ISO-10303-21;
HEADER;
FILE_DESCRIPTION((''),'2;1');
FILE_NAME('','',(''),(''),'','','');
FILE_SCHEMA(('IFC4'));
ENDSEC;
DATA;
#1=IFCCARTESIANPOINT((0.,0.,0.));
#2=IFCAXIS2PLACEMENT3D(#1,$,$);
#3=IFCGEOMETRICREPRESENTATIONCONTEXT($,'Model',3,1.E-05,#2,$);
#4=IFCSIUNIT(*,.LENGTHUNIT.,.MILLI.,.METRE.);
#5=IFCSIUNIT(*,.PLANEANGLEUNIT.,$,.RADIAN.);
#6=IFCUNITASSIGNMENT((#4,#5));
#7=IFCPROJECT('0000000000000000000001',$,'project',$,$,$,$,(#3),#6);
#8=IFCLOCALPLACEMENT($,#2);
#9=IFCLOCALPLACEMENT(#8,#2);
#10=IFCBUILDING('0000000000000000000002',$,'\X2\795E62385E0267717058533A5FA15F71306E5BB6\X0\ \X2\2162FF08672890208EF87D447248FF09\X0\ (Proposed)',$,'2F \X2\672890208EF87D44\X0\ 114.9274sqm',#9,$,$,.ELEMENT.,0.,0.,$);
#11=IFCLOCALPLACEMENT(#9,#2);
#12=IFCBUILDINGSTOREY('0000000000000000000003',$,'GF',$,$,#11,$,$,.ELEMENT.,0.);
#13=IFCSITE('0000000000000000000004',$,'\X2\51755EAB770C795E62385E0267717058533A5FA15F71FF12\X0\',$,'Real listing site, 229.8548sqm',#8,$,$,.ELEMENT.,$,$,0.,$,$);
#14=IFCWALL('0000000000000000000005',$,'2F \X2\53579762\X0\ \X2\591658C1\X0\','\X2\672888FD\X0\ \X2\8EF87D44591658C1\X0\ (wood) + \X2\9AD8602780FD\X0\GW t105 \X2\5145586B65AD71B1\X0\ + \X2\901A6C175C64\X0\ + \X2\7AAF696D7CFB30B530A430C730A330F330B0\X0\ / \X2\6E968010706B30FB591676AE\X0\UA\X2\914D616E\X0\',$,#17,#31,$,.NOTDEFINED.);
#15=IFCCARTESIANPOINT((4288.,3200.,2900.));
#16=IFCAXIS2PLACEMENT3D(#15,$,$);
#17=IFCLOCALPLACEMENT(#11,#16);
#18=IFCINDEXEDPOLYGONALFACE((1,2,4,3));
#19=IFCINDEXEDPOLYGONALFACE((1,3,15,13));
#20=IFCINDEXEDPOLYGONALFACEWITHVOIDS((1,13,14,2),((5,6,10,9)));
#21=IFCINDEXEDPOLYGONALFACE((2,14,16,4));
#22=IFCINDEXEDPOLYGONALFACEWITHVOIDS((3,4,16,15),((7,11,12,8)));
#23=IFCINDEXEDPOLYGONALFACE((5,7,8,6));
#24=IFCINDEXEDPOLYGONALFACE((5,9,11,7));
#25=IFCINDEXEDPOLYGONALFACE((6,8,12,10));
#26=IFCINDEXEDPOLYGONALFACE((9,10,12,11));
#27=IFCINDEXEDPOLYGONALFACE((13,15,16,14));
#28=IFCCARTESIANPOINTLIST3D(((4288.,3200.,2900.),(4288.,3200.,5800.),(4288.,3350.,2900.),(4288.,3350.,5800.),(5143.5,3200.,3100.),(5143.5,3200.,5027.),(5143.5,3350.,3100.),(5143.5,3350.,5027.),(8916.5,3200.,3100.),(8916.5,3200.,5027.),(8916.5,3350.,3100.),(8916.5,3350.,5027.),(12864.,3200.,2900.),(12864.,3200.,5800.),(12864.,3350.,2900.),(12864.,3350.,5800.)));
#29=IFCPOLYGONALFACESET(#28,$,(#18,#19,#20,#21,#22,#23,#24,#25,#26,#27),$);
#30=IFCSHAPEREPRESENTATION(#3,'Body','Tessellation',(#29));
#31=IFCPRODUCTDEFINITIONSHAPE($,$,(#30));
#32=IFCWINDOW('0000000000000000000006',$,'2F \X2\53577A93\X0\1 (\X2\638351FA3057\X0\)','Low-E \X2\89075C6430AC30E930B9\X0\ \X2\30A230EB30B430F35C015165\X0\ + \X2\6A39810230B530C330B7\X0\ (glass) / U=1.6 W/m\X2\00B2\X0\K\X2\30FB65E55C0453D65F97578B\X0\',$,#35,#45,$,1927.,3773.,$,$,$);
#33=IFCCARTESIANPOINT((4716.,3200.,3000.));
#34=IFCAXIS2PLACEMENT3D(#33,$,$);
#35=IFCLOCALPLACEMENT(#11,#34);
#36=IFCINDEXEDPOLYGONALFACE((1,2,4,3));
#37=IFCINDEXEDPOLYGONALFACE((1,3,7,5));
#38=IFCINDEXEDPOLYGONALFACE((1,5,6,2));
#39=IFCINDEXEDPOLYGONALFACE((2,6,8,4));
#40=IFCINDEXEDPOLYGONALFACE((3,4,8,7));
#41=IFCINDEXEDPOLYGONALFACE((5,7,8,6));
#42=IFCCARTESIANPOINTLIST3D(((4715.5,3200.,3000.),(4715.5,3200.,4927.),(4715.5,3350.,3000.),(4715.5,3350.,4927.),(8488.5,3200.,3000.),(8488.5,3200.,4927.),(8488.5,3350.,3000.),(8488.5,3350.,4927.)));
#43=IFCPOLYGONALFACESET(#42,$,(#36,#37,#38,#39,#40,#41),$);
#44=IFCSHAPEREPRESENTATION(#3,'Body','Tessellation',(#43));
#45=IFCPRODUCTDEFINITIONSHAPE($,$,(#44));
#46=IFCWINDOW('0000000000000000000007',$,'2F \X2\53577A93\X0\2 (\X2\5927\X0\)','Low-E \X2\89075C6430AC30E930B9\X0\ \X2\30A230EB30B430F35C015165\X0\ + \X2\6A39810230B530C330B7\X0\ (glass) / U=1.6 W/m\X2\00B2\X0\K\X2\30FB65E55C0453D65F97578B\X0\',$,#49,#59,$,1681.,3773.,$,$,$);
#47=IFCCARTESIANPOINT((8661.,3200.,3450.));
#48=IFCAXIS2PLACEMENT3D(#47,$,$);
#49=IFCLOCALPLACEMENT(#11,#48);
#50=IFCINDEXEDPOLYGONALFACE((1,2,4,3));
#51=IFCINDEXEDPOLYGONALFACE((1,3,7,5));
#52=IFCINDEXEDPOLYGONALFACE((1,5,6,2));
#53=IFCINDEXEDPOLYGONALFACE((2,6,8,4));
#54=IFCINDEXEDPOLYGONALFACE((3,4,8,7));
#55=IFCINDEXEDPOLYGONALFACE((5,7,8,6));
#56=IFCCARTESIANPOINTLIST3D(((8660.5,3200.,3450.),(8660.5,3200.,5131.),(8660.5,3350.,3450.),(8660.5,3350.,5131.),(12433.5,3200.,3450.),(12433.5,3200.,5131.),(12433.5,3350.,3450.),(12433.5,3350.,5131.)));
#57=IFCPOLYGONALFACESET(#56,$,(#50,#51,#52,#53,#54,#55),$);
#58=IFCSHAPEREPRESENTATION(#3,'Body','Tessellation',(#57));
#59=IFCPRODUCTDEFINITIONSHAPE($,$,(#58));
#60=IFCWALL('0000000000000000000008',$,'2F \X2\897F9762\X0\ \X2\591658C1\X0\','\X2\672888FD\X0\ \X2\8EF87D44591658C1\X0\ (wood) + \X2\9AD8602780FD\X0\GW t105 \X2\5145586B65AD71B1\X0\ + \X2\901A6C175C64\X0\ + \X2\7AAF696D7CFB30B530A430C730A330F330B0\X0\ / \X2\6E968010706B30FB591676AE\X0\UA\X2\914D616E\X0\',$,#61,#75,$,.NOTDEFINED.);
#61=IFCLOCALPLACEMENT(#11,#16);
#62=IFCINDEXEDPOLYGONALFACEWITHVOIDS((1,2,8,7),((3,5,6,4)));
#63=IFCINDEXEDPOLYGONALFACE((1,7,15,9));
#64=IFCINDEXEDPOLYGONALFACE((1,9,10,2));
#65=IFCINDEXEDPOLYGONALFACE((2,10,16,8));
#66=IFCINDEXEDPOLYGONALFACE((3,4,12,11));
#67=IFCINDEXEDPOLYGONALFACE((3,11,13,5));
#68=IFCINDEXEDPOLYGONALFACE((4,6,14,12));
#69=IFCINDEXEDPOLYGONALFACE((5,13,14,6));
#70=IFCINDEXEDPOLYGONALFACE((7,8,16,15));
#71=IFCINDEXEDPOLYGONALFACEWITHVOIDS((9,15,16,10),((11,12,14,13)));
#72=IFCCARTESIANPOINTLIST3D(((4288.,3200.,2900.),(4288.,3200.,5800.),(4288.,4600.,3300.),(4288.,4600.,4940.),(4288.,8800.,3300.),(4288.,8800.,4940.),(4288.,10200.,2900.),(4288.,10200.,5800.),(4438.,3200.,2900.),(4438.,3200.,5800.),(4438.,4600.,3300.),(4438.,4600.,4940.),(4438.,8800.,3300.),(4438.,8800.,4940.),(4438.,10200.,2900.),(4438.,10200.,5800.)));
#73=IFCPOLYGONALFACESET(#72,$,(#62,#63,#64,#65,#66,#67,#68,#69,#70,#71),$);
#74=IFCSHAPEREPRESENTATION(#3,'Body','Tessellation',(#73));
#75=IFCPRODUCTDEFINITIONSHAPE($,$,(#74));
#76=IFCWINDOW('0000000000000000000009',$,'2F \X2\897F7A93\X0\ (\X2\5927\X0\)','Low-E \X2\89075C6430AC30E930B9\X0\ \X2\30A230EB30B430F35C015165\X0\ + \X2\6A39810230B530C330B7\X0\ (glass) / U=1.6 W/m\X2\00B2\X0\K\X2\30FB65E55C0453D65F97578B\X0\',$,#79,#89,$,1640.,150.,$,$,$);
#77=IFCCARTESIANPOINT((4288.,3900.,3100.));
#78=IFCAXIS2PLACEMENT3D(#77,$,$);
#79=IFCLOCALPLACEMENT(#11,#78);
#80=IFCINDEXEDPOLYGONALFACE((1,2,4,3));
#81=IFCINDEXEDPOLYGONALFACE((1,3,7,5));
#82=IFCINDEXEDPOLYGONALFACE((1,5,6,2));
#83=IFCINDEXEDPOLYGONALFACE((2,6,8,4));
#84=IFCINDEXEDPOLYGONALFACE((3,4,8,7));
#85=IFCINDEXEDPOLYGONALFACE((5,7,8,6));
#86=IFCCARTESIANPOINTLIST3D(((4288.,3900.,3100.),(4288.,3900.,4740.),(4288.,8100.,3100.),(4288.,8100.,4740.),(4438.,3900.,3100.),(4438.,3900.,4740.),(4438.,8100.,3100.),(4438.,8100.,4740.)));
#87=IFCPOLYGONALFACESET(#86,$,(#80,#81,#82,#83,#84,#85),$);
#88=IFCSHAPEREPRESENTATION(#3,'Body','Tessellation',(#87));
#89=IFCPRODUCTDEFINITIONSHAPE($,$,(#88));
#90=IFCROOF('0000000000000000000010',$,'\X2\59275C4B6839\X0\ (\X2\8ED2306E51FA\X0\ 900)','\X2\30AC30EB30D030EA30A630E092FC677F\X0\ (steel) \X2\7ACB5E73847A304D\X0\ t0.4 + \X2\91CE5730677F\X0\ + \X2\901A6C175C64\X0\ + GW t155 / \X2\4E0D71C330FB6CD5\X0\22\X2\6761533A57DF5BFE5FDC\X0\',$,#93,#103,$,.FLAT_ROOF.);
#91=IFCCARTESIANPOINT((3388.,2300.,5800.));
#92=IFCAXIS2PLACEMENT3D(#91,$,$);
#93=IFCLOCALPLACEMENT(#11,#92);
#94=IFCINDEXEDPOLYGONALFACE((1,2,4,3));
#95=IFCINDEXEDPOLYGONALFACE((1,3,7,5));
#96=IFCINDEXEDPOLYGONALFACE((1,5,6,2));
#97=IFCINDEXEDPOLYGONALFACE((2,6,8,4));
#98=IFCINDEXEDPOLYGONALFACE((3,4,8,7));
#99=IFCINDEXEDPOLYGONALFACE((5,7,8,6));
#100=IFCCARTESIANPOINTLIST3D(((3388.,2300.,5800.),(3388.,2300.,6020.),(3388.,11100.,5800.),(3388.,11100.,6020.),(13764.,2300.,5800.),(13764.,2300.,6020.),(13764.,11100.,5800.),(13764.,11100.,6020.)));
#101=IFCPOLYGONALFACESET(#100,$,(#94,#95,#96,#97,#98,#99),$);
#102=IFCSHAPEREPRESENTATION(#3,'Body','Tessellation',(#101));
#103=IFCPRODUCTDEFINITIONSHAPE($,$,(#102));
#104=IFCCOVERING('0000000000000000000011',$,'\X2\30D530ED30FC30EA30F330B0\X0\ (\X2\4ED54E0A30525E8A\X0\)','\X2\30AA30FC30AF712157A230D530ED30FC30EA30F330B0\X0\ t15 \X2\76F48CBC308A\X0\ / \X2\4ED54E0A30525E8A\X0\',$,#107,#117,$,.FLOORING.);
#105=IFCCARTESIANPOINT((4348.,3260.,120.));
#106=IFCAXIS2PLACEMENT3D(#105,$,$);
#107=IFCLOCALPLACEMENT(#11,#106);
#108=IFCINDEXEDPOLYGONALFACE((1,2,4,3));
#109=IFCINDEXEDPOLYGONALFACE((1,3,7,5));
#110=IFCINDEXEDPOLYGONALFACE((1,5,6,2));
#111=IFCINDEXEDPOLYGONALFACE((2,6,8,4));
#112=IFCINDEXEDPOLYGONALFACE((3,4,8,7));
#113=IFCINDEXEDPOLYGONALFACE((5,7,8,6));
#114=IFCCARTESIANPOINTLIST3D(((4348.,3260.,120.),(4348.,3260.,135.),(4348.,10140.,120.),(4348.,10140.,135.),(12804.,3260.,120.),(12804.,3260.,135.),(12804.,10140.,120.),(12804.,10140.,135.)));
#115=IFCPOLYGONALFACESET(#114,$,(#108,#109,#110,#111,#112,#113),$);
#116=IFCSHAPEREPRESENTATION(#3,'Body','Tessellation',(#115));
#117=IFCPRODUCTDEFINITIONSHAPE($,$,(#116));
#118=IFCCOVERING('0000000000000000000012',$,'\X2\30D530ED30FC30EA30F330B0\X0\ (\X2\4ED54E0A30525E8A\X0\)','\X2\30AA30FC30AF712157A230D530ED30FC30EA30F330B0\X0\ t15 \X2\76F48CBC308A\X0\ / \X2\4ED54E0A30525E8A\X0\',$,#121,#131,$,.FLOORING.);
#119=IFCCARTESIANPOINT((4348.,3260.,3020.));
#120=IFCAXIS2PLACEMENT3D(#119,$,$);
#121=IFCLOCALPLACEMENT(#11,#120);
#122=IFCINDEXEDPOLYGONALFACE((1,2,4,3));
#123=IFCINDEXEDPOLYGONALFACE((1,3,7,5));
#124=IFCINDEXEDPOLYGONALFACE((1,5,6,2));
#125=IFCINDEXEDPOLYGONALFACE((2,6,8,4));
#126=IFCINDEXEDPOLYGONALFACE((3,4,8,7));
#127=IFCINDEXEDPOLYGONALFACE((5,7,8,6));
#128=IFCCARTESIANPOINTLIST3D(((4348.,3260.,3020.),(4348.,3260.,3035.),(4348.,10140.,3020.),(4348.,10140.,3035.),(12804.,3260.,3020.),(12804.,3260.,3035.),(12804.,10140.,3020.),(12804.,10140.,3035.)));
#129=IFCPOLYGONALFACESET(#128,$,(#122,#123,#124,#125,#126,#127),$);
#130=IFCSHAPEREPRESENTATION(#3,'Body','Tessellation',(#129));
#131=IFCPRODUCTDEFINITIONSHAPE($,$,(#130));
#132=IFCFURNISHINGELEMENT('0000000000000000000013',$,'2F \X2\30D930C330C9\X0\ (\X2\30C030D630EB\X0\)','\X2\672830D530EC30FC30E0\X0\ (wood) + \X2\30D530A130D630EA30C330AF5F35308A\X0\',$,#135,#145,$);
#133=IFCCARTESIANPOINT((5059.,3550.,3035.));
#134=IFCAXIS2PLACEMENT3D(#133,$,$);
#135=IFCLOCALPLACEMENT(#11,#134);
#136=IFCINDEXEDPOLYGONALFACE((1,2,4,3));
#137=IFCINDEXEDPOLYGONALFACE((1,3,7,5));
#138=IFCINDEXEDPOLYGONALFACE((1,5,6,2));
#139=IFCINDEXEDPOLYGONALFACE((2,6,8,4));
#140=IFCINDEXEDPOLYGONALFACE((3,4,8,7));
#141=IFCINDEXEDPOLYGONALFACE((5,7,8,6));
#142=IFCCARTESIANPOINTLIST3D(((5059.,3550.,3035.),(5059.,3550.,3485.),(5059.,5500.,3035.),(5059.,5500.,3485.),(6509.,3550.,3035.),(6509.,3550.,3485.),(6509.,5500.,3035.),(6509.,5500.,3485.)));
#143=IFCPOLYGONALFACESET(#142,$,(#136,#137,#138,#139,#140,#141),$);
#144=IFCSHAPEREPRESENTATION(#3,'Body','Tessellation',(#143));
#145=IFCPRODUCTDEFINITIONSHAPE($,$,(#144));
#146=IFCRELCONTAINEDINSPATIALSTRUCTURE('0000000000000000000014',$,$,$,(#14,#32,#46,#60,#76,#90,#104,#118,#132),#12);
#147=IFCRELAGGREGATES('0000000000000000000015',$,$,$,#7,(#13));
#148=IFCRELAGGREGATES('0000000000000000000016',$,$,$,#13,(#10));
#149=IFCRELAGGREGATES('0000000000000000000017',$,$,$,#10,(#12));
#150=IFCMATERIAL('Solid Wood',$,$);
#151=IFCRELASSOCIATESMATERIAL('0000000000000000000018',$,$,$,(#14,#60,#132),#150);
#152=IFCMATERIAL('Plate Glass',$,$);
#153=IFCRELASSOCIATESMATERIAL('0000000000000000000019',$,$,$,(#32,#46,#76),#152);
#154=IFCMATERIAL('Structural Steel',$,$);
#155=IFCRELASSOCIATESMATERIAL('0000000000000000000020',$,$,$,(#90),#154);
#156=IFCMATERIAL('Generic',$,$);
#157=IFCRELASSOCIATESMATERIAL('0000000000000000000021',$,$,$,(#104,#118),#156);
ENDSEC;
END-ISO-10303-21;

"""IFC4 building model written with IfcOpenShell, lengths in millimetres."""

from ifc_helpers import new_model, si_unit, frame, frame_2d, origin, place, context, project, spatial, rectangle, extrude, material, element, fill, save


model = new_model("IFC4")

# Units and contexts
model_context = context("Model", 3, precision=1e-05, world=origin())
ifc_project = project(units=[si_unit("LENGTHUNIT", "METRE", prefix="MILLI"), si_unit("PLANEANGLEUNIT", "RADIAN")], contexts=[model_context])

# Site, building, storey
site_placement = place(None, origin())
site = spatial("IfcSite", under=ifc_project, at=site_placement, Name="兵庫県神戸市東灘区御影２", ObjectType="Real listing site, 229.8548sqm", CompositionType="ELEMENT", RefElevation=0.0)
building_placement = place(site_placement, origin())
building = spatial("IfcBuilding", under=site, at=building_placement, Name="神戸市東灘区御影の家 Ⅲ（木造軸組版） (Proposed)", ObjectType="2F 木造軸組 114.9274sqm", CompositionType="ELEMENT", ElevationOfRefHeight=0.0, ElevationOfTerrain=0.0)
storey_placement = place(building_placement, origin())
storey = spatial("IfcBuildingStorey", under=building, at=storey_placement, Name="GF", CompositionType="ELEMENT", Elevation=0.0)

# Shared definitions
ifc_material_1 = material(Name="Solid Wood")

# Shared definitions
ifc_material_2 = material(Name="Plate Glass")

# Wall, openings, windows
wall_1_placement = place(storey_placement, frame((4288.0, 3200.0, 2900.0)))
wall_1 = element("IfcWall", 1, at=wall_1_placement, inside=storey, material=ifc_material_1, Name="2F 南面 外壁", Description="木製 軸組外壁 (wood) + 高性能GW t105 充填断熱 + 通気層 + 窯業系サイディング / 準耐火・外皮UA配慮", PredefinedType="NOTDEFINED", context=model_context, shape_type="SweptSolid", body=[
    extrude(rectangle(XDim=8576.0, YDim=150.0, at=frame_2d((4288.0, 75.0))), frame((4288.0, 3200.0, 2900.0)), (0.0, 0.0, 1.0), 2900.0),
])
opening_1_placement = place(storey_placement, frame((4716.0, 3200.0, 3000.0)))
opening_1 = element("IfcOpeningElement", 2, at=opening_1_placement, cuts=wall_1, PredefinedType="NOTDEFINED", context=model_context, shape_type="SweptSolid", body=[
    extrude(rectangle(XDim=3773.0, YDim=150.0, at=frame_2d((1886.0, 75.0))), frame((4716.0, 3200.0, 3000.0)), (0.0, 0.0, 1.0), 1927.0),
])
opening_2_placement = place(storey_placement, frame((8661.0, 3200.0, 3450.0)))
opening_2 = element("IfcOpeningElement", 3, at=opening_2_placement, cuts=wall_1, PredefinedType="NOTDEFINED", context=model_context, shape_type="SweptSolid", body=[
    extrude(rectangle(XDim=3773.0, YDim=150.0, at=frame_2d((1886.0, 75.0))), frame((8661.0, 3200.0, 3450.0)), (0.0, 0.0, 1.0), 1681.0),
])
window_1_placement = place(storey_placement, frame((4716.0, 3200.0, 3000.0)))
window_1 = element("IfcWindow", 4, at=window_1_placement, inside=storey, material=ifc_material_2, Name="2F 南窓1 (掃出し)", Description="Low-E 複層ガラス アルゴン封入 + 樹脂サッシ (glass) / U=1.6 W/m²K・日射取得型", OverallHeight=1927.0, OverallWidth=3773.0, context=model_context, shape_type="SweptSolid", body=[
    extrude(rectangle(XDim=3773.0, YDim=150.0, at=frame_2d((1886.0, 75.0))), frame((4716.0, 3200.0, 3000.0)), (0.0, 0.0, 1.0), 1927.0),
])
fill(opening_1, window_1)
window_2_placement = place(storey_placement, frame((8661.0, 3200.0, 3450.0)))
window_2 = element("IfcWindow", 5, at=window_2_placement, inside=storey, material=ifc_material_2, Name="2F 南窓2 (大)", Description="Low-E 複層ガラス アルゴン封入 + 樹脂サッシ (glass) / U=1.6 W/m²K・日射取得型", OverallHeight=1681.0, OverallWidth=3773.0, context=model_context, shape_type="SweptSolid", body=[
    extrude(rectangle(XDim=3773.0, YDim=150.0, at=frame_2d((1886.0, 75.0))), frame((8661.0, 3200.0, 3450.0)), (0.0, 0.0, 1.0), 1681.0),
])
fill(opening_2, window_2)

# Wall, opening, window
wall_2_placement = place(storey_placement, frame((4288.0, 3200.0, 2900.0)))
wall_2 = element("IfcWall", 6, at=wall_2_placement, inside=storey, material=ifc_material_1, Name="2F 西面 外壁", Description="木製 軸組外壁 (wood) + 高性能GW t105 充填断熱 + 通気層 + 窯業系サイディング / 準耐火・外皮UA配慮", PredefinedType="NOTDEFINED", context=model_context, shape_type="SweptSolid", body=[
    extrude(rectangle(XDim=150.0, YDim=7000.0, at=frame_2d((75.0, 3500.0))), frame((4288.0, 3200.0, 2900.0)), (0.0, 0.0, 1.0), 2900.0),
])
opening_3_placement = place(storey_placement, frame((4288.0, 3900.0, 3100.0)))
opening_3 = element("IfcOpeningElement", 7, at=opening_3_placement, cuts=wall_2, PredefinedType="NOTDEFINED", context=model_context, shape_type="SweptSolid", body=[
    extrude(rectangle(XDim=150.0, YDim=4200.0, at=frame_2d((75.0, 2100.0))), frame((4288.0, 3900.0, 3100.0)), (0.0, 0.0, 1.0), 1640.0),
])
window_3_placement = place(storey_placement, frame((4288.0, 3900.0, 3100.0)))
window_3 = element("IfcWindow", 8, at=window_3_placement, inside=storey, material=ifc_material_2, Name="2F 西窓 (大)", Description="Low-E 複層ガラス アルゴン封入 + 樹脂サッシ (glass) / U=1.6 W/m²K・日射取得型", OverallHeight=1640.0, OverallWidth=150.0, context=model_context, shape_type="SweptSolid", body=[
    extrude(rectangle(XDim=150.0, YDim=4200.0, at=frame_2d((75.0, 2100.0))), frame((4288.0, 3900.0, 3100.0)), (0.0, 0.0, 1.0), 1640.0),
])
fill(opening_3, window_3)

# Roof
ifc_material_3 = material(Name="Structural Steel")
roof_placement = place(storey_placement, frame((3388.0, 2300.0, 5800.0)))
element("IfcRoof", 9, at=roof_placement, inside=storey, material=ifc_material_3, Name="大屋根 (軒の出 900)", Description="ガルバリウム鋼板 (steel) 立平葺き t0.4 + 野地板 + 通気層 + GW t155 / 不燃・法22条区域対応", PredefinedType="FLAT_ROOF", context=model_context, shape_type="SweptSolid", body=[
    extrude(rectangle(XDim=10376.0, YDim=8800.0, at=frame_2d((5188.0, 4400.0))), frame((3388.0, 2300.0, 5800.0)), (0.0, 0.0, 1.0), 220.0),
])

# Coverings
ifc_material_4 = material(Name="Generic")
covering_1_placement = place(storey_placement, frame((4348.0, 3260.0, 120.0)))
element("IfcCovering", 10, at=covering_1_placement, inside=storey, material=ifc_material_4, Name="フローリング (仕上げ床)", Description="オーク無垢フローリング t15 直貼り / 仕上げ床", PredefinedType="FLOORING", context=model_context, shape_type="SweptSolid", body=[
    extrude(rectangle(XDim=8456.0, YDim=6880.0, at=frame_2d((4228.0, 3440.0))), frame((4348.0, 3260.0, 120.0)), (0.0, 0.0, 1.0), 15.0),
])
covering_2_placement = place(storey_placement, frame((4348.0, 3260.0, 3020.0)))
element("IfcCovering", 11, at=covering_2_placement, inside=storey, material=ifc_material_4, Name="フローリング (仕上げ床)", Description="オーク無垢フローリング t15 直貼り / 仕上げ床", PredefinedType="FLOORING", context=model_context, shape_type="SweptSolid", body=[
    extrude(rectangle(XDim=8456.0, YDim=6880.0, at=frame_2d((4228.0, 3440.0))), frame((4348.0, 3260.0, 3020.0)), (0.0, 0.0, 1.0), 15.0),
])

# Furnishing element
furnishing_placement = place(storey_placement, frame((5059.0, 3550.0, 3035.0)))
element("IfcFurnishingElement", 12, at=furnishing_placement, inside=storey, material=ifc_material_1, Name="2F ベッド (ダブル)", Description="木フレーム (wood) + ファブリック張り", context=model_context, shape_type="SweptSolid", body=[
    extrude(rectangle(XDim=1450.0, YDim=1950.0, at=frame_2d((725.0, 975.0))), frame((5059.0, 3550.0, 3035.0)), (0.0, 0.0, 1.0), 450.0),
])

save(model, "model.ifc")
